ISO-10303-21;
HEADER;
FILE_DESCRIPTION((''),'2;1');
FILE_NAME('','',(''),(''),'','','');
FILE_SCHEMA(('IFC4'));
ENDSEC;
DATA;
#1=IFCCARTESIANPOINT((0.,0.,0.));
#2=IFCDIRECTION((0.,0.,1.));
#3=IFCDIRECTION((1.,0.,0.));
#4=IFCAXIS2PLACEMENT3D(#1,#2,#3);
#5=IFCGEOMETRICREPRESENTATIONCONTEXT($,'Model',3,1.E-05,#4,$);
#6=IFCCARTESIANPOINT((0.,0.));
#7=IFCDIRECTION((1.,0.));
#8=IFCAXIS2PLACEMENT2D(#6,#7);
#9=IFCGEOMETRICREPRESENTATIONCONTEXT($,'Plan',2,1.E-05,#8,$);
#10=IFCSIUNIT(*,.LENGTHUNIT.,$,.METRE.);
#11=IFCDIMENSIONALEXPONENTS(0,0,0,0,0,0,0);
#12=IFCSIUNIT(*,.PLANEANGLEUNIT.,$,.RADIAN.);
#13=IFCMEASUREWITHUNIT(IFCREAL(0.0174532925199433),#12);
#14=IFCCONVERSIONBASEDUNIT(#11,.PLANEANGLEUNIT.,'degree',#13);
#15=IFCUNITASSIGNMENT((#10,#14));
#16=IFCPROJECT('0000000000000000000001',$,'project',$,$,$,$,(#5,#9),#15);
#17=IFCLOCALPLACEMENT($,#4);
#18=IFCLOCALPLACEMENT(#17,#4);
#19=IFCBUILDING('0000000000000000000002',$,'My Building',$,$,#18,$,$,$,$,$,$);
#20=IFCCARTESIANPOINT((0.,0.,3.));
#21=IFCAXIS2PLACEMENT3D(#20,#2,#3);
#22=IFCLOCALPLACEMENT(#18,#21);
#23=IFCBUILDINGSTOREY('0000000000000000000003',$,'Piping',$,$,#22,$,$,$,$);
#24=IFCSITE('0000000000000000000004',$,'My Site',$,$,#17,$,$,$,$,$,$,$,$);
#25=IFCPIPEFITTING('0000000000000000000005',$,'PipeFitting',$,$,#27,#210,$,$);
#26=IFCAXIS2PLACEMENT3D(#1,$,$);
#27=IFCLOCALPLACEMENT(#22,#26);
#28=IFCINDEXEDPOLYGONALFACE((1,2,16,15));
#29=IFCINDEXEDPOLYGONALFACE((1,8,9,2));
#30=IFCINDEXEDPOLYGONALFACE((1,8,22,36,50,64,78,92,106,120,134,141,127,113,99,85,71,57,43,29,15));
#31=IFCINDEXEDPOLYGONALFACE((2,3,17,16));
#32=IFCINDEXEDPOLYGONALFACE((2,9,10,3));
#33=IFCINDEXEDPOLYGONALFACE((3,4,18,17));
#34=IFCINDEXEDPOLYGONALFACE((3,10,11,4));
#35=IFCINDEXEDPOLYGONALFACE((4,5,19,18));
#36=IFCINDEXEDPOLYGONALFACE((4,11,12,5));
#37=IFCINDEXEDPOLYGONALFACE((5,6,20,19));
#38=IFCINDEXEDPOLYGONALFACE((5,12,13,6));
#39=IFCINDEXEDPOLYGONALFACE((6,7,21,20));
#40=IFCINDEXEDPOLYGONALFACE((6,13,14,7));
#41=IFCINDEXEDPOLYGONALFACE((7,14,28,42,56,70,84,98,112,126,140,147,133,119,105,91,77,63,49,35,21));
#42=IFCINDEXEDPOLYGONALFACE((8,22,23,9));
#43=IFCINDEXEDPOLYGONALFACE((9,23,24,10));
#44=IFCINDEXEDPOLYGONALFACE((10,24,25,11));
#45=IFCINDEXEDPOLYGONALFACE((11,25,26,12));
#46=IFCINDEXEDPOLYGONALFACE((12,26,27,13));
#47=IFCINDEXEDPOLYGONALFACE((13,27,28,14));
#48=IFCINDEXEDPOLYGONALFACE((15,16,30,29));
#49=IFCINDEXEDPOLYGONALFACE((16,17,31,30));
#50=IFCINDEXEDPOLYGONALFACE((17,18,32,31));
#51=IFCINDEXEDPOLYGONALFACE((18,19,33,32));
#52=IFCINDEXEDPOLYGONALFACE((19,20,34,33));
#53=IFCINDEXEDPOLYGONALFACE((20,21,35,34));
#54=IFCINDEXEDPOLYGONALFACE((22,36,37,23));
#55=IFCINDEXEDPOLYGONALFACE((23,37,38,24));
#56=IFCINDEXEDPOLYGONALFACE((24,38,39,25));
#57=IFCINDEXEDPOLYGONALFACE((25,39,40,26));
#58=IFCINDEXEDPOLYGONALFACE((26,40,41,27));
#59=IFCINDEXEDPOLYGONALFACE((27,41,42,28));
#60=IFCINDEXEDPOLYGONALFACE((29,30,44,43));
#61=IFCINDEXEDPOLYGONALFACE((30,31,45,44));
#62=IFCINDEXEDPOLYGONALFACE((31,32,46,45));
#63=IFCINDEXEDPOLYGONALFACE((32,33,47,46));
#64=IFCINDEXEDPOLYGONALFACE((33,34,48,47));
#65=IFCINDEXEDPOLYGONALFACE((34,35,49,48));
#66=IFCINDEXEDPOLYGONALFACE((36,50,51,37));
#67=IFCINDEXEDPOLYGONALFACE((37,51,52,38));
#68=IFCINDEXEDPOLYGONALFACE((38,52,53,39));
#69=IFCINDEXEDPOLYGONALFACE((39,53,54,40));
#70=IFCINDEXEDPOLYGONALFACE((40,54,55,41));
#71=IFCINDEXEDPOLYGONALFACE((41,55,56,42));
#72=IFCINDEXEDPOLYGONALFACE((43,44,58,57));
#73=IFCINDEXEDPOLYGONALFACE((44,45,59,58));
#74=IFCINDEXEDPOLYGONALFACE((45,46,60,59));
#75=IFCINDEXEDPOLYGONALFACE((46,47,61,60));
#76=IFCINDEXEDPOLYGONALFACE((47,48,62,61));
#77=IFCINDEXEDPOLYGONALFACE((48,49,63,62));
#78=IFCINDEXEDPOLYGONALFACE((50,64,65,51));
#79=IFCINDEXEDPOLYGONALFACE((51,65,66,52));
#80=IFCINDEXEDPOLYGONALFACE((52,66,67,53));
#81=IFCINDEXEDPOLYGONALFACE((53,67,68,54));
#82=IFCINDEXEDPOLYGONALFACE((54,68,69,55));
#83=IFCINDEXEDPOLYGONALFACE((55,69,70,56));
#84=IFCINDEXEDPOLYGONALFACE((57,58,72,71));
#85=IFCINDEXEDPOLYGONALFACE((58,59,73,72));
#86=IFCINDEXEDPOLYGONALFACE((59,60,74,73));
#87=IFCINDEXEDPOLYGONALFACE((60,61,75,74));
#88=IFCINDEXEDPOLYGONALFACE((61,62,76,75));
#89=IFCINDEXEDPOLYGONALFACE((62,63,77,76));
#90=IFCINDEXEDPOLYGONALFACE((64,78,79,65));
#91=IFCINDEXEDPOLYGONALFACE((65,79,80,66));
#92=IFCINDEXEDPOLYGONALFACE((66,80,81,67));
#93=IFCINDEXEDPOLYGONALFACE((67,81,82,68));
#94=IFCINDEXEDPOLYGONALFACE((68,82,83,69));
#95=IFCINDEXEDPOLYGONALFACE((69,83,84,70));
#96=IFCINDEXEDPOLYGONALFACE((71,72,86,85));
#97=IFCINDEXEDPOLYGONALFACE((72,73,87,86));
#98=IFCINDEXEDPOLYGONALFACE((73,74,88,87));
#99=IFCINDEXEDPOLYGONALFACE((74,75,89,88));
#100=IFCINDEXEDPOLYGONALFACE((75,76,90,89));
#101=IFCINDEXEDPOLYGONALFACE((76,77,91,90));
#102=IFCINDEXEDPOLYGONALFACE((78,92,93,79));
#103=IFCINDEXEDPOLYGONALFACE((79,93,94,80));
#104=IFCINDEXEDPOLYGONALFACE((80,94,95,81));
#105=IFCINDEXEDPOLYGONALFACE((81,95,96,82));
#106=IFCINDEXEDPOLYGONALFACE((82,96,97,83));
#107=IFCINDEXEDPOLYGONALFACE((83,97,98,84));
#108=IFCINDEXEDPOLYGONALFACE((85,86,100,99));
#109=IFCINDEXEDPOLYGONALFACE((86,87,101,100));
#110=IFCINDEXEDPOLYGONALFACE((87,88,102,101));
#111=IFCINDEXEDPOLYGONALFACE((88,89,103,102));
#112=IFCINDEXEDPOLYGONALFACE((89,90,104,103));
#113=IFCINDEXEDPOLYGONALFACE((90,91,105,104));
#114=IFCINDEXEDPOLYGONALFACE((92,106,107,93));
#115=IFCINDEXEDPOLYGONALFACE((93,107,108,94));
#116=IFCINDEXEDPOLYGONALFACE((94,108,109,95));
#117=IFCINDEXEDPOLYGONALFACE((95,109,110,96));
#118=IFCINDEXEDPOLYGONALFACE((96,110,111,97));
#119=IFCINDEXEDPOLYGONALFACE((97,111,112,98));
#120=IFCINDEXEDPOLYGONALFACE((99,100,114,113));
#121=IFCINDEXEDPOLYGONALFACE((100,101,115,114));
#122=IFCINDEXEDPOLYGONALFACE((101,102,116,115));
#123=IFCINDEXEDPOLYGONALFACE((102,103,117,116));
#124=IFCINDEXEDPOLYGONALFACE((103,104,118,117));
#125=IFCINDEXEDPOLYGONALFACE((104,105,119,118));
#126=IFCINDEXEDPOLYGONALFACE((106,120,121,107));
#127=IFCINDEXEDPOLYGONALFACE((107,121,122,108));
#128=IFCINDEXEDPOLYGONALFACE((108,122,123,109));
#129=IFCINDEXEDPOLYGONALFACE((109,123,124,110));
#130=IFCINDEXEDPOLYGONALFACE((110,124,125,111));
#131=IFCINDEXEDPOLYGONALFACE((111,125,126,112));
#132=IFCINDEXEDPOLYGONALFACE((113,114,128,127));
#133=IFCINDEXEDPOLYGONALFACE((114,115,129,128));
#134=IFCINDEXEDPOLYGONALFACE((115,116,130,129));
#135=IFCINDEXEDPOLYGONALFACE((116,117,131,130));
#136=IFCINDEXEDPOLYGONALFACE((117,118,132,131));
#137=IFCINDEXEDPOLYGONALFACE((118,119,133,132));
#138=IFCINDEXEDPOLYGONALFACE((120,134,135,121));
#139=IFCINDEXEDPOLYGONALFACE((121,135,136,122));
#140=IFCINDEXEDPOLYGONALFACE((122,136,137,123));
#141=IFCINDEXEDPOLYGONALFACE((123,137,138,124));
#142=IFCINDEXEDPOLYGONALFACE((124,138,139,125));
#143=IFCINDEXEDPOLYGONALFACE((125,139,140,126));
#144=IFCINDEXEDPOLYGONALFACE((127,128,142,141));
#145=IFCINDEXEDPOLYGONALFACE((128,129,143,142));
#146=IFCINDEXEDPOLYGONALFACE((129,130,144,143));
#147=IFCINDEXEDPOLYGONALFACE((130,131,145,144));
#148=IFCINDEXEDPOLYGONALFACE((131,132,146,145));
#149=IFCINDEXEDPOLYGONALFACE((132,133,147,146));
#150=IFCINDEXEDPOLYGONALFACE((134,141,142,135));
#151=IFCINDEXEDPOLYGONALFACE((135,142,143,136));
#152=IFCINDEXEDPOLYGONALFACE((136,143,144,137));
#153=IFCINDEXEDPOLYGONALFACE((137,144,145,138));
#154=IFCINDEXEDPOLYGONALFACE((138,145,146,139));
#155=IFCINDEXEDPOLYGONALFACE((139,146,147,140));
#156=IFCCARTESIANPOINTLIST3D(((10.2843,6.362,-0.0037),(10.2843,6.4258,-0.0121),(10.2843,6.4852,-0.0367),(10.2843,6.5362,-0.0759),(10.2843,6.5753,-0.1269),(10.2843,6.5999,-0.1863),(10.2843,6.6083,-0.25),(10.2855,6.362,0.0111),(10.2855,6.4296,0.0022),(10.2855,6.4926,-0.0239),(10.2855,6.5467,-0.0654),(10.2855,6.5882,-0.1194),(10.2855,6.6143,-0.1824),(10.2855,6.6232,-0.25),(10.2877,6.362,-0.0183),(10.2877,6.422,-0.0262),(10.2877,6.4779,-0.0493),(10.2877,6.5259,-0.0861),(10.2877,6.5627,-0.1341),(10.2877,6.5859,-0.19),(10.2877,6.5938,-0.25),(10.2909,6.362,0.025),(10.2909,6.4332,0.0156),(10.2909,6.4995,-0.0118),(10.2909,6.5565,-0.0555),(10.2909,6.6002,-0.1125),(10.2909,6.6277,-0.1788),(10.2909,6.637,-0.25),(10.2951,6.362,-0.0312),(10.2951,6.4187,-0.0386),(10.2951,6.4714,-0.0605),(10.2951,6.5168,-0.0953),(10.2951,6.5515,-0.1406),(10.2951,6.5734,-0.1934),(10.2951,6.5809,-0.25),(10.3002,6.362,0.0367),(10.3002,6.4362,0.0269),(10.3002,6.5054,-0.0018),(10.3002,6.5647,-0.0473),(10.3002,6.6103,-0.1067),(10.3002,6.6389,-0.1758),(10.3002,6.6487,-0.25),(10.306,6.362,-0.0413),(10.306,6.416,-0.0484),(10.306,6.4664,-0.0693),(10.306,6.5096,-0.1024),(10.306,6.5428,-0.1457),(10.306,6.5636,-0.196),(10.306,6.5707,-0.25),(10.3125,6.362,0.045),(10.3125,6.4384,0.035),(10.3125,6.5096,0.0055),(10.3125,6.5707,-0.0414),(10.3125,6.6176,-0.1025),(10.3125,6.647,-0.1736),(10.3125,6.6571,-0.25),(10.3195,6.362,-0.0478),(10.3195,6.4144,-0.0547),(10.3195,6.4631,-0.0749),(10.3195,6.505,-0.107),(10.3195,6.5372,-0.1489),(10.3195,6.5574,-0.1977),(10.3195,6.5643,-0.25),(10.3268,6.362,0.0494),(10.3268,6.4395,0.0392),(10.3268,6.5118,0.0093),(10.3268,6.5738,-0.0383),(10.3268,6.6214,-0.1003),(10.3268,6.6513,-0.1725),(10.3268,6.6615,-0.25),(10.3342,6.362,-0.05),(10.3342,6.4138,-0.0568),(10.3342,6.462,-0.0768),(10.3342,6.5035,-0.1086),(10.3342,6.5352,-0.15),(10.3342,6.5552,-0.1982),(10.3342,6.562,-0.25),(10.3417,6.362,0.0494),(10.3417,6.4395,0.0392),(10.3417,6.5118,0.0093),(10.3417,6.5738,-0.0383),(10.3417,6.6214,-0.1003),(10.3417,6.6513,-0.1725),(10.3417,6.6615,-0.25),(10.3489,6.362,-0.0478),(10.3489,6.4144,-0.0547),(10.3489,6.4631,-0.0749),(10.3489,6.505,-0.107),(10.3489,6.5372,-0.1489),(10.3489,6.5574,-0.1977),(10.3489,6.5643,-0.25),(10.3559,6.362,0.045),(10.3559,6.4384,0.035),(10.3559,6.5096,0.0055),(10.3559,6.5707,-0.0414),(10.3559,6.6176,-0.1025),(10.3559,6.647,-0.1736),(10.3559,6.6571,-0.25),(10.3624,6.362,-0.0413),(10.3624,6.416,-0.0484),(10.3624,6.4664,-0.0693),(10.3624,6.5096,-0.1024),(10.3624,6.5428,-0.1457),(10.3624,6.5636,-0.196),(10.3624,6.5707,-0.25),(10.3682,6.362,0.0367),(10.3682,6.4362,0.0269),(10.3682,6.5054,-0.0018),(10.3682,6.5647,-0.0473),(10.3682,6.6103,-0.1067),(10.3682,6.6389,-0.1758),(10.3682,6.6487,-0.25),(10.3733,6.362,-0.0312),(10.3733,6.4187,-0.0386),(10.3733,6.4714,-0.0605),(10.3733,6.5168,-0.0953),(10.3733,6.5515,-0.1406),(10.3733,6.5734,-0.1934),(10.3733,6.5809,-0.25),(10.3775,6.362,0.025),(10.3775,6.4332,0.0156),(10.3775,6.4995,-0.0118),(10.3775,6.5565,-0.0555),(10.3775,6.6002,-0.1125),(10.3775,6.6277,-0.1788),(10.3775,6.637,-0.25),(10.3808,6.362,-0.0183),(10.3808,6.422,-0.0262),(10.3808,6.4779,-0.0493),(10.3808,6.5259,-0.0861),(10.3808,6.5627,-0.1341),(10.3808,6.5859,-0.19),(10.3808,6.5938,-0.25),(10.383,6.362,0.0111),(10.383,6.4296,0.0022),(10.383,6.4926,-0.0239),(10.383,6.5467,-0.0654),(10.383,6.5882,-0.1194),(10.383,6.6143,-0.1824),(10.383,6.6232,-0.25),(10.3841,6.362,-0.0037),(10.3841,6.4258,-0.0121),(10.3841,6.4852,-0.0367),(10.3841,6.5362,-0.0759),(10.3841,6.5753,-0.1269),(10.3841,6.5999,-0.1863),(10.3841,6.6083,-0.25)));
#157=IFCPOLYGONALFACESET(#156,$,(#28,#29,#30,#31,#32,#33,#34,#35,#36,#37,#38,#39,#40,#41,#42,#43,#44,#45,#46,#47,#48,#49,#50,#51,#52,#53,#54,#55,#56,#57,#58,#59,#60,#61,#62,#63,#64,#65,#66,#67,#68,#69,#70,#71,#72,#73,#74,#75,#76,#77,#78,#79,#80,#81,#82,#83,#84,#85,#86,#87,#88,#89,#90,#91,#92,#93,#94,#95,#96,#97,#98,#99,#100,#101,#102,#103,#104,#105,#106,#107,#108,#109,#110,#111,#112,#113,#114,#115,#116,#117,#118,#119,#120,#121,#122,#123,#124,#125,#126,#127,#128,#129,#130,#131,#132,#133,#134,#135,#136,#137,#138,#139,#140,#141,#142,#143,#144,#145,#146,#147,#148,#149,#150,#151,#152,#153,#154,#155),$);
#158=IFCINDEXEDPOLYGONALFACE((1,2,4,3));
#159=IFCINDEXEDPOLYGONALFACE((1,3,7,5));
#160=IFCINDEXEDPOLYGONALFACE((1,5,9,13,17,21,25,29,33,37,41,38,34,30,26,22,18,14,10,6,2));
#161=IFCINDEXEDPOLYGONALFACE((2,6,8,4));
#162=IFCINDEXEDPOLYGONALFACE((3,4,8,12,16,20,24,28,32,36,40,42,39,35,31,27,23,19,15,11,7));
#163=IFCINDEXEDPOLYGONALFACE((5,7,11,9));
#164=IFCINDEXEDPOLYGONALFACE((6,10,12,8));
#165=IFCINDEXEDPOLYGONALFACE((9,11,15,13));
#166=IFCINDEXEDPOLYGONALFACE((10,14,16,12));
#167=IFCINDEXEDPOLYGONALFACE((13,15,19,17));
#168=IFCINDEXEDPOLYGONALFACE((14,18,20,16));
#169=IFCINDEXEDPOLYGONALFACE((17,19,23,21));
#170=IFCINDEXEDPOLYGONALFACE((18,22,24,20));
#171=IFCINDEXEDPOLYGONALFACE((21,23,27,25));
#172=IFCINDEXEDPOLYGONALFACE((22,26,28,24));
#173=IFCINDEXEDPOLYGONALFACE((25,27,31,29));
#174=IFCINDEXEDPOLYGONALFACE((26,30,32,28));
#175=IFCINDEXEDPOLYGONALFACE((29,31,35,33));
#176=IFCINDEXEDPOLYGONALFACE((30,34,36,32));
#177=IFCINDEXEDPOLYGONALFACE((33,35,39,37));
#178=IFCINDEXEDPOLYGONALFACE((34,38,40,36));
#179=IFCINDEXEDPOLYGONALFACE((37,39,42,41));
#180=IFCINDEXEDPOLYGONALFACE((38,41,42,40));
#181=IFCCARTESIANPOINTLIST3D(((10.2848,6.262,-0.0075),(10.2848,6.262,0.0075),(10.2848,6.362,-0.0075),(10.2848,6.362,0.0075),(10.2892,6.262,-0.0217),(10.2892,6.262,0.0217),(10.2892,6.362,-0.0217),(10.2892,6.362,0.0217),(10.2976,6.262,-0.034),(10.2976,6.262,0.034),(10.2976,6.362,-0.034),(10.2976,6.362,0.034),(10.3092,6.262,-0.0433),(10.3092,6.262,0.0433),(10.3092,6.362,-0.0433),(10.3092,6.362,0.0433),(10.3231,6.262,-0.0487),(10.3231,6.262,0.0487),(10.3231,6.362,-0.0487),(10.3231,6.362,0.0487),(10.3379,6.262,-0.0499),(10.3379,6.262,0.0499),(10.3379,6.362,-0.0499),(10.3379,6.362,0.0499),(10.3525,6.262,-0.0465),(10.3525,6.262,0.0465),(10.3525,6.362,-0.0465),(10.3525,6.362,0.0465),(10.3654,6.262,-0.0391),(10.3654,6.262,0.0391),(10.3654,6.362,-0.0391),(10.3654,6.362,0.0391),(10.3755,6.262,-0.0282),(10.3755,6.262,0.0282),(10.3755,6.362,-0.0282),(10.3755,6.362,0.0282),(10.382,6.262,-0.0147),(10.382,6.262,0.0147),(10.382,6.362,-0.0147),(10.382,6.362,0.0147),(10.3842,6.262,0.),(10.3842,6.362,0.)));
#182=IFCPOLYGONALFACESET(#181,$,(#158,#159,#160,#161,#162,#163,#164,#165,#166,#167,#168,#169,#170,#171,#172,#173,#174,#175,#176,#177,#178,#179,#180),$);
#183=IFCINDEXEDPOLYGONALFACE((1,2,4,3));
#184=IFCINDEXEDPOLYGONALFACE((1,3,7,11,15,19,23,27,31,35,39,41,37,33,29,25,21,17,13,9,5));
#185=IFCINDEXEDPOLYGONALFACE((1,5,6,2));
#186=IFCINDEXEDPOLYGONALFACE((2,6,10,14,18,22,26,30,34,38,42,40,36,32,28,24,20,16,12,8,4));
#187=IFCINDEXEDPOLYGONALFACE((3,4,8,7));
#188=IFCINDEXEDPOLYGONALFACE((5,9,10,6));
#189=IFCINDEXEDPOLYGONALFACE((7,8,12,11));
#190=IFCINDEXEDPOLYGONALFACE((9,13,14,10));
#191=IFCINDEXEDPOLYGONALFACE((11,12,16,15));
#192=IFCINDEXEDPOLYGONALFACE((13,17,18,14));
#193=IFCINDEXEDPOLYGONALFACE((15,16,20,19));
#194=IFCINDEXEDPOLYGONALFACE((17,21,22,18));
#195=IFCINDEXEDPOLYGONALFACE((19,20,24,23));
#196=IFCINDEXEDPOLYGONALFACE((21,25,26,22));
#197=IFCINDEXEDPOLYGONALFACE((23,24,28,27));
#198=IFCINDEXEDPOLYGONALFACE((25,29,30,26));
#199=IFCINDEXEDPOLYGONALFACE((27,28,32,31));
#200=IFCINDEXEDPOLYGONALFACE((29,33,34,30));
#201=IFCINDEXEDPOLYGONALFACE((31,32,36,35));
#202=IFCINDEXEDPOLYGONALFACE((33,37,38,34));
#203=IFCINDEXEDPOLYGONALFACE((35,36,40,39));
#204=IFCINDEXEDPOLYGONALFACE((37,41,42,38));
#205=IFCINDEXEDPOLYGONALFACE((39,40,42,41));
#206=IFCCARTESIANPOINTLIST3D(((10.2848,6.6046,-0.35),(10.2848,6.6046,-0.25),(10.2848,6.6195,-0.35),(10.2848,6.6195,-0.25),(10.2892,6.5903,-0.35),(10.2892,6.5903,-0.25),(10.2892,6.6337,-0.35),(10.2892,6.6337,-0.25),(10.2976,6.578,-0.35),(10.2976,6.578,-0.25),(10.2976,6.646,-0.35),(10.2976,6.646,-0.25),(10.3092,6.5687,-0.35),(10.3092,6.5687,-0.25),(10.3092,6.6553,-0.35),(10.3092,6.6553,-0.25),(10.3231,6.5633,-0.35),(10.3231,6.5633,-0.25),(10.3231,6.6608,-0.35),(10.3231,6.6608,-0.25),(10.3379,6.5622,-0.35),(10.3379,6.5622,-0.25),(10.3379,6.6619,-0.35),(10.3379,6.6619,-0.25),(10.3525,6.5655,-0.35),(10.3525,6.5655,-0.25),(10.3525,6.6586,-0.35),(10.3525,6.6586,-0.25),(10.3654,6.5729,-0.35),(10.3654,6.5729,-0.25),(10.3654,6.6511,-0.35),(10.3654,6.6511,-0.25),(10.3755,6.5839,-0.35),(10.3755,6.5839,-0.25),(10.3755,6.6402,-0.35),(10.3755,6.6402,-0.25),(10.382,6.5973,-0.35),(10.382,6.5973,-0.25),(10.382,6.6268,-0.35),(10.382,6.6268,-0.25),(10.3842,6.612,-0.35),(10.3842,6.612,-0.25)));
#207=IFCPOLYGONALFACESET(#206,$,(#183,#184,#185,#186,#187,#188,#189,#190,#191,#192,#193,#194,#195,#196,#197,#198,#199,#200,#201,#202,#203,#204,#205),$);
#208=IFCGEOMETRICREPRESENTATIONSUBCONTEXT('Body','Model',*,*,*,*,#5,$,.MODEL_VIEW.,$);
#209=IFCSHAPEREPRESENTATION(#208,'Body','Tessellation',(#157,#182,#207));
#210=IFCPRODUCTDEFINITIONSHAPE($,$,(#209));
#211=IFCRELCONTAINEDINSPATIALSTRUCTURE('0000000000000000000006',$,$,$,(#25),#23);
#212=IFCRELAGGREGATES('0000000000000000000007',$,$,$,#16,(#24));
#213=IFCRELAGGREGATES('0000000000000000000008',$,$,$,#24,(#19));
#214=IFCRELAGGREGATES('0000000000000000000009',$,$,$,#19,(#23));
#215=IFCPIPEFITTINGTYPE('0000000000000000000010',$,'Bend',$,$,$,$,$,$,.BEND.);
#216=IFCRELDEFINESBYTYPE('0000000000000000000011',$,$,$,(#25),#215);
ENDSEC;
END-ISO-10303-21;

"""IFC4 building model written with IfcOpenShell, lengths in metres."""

from ifc_helpers import new_model, entity, si_unit, converted_unit, frame, origin_with_axes, origin_2d_with_axis, place, context, subcontext, project, spatial, circle, extrude, source, transform, mapped, type_object, type_shapes, element, save


model = new_model("IFC4")

# Units and contexts
model_context = context("Model", 3, precision=1e-05, world=origin_with_axes())
plan_context = context("Plan", 2, precision=1e-05, world=origin_2d_with_axis())
body_context = subcontext(model_context, "Body", "Model", "MODEL_VIEW")
ifc_project = project(units=[si_unit("LENGTHUNIT", "METRE"), converted_unit("PLANEANGLEUNIT", "degree", entity("IfcReal", 0.0174532925199433), si_unit("PLANEANGLEUNIT", "RADIAN"), dimensions=[0, 0, 0, 0, 0, 0, 0])], contexts=[model_context, plan_context])

# Site, building, storey
site_placement = place(None, origin_with_axes())
site = spatial("IfcSite", under=ifc_project, at=site_placement, Name="My Site")
building_placement = place(site_placement, origin_with_axes())
building = spatial("IfcBuilding", under=site, at=building_placement, Name="My Building")
storey_placement = place(building_placement, frame((0.0, 0.0, 3.0), z_axis=(0.0, 0.0, 1.0), x_axis=(1.0, 0.0, 0.0)))
storey = spatial("IfcBuildingStorey", under=building, at=storey_placement, Name="Piping")

# Pipe fitting
pipe_fitting_type = type_object("IfcPipeFittingType", Name="Bend", PredefinedType="BEND")
shared_shape = source(origin_with_axes(), body_context, "Body", "SolidModel", [
    entity("IfcSweptDiskSolid", entity("IfcIndexedPolyCurve", entity("IfcCartesianPointList3D", [[0.0, 0.0, -0.1], [0.0, -0.0732, -0.2768], [0.0, -0.25, -0.35]]), [entity("IfcArcIndex", [1, 2, 3])]), 0.05),
    extrude(circle(Radius=0.05), origin_with_axes(), (0.0, 0.0, -1.0), 0.1),
    extrude(circle(Radius=0.05), frame((0.0, -0.25, -0.35), z_axis=(0.0, -1.0, 0.0), x_axis=(1.0, 0.0, 0.0)), (0.0, 0.0, 1.0), 0.1),
])
type_shapes(pipe_fitting_type, [shared_shape])
for number, where, z_axis, x_axis, name in (
    (1, (10.3342, 6.262, 0.0), (0.0, -1.0, 0.0), (1.0, 0.0, 0.0), "PipeFitting"),
):
    element("IfcPipeFitting", number, at=place(storey_placement, frame(where, z_axis=z_axis, x_axis=x_axis)), inside=storey, type_object=pipe_fitting_type, Name=name, context=body_context, shape_type="MappedRepresentation", body=[
        mapped(shared_shape, transform((0.0, 0.0, 0.0), x_axis=(1.0, 0.0, 0.0), y_axis=(0.0, 1.0, 0.0), z_axis=(0.0, 0.0, 1.0), scale=1.0)),
    ])

save(model, "model.ifc")
